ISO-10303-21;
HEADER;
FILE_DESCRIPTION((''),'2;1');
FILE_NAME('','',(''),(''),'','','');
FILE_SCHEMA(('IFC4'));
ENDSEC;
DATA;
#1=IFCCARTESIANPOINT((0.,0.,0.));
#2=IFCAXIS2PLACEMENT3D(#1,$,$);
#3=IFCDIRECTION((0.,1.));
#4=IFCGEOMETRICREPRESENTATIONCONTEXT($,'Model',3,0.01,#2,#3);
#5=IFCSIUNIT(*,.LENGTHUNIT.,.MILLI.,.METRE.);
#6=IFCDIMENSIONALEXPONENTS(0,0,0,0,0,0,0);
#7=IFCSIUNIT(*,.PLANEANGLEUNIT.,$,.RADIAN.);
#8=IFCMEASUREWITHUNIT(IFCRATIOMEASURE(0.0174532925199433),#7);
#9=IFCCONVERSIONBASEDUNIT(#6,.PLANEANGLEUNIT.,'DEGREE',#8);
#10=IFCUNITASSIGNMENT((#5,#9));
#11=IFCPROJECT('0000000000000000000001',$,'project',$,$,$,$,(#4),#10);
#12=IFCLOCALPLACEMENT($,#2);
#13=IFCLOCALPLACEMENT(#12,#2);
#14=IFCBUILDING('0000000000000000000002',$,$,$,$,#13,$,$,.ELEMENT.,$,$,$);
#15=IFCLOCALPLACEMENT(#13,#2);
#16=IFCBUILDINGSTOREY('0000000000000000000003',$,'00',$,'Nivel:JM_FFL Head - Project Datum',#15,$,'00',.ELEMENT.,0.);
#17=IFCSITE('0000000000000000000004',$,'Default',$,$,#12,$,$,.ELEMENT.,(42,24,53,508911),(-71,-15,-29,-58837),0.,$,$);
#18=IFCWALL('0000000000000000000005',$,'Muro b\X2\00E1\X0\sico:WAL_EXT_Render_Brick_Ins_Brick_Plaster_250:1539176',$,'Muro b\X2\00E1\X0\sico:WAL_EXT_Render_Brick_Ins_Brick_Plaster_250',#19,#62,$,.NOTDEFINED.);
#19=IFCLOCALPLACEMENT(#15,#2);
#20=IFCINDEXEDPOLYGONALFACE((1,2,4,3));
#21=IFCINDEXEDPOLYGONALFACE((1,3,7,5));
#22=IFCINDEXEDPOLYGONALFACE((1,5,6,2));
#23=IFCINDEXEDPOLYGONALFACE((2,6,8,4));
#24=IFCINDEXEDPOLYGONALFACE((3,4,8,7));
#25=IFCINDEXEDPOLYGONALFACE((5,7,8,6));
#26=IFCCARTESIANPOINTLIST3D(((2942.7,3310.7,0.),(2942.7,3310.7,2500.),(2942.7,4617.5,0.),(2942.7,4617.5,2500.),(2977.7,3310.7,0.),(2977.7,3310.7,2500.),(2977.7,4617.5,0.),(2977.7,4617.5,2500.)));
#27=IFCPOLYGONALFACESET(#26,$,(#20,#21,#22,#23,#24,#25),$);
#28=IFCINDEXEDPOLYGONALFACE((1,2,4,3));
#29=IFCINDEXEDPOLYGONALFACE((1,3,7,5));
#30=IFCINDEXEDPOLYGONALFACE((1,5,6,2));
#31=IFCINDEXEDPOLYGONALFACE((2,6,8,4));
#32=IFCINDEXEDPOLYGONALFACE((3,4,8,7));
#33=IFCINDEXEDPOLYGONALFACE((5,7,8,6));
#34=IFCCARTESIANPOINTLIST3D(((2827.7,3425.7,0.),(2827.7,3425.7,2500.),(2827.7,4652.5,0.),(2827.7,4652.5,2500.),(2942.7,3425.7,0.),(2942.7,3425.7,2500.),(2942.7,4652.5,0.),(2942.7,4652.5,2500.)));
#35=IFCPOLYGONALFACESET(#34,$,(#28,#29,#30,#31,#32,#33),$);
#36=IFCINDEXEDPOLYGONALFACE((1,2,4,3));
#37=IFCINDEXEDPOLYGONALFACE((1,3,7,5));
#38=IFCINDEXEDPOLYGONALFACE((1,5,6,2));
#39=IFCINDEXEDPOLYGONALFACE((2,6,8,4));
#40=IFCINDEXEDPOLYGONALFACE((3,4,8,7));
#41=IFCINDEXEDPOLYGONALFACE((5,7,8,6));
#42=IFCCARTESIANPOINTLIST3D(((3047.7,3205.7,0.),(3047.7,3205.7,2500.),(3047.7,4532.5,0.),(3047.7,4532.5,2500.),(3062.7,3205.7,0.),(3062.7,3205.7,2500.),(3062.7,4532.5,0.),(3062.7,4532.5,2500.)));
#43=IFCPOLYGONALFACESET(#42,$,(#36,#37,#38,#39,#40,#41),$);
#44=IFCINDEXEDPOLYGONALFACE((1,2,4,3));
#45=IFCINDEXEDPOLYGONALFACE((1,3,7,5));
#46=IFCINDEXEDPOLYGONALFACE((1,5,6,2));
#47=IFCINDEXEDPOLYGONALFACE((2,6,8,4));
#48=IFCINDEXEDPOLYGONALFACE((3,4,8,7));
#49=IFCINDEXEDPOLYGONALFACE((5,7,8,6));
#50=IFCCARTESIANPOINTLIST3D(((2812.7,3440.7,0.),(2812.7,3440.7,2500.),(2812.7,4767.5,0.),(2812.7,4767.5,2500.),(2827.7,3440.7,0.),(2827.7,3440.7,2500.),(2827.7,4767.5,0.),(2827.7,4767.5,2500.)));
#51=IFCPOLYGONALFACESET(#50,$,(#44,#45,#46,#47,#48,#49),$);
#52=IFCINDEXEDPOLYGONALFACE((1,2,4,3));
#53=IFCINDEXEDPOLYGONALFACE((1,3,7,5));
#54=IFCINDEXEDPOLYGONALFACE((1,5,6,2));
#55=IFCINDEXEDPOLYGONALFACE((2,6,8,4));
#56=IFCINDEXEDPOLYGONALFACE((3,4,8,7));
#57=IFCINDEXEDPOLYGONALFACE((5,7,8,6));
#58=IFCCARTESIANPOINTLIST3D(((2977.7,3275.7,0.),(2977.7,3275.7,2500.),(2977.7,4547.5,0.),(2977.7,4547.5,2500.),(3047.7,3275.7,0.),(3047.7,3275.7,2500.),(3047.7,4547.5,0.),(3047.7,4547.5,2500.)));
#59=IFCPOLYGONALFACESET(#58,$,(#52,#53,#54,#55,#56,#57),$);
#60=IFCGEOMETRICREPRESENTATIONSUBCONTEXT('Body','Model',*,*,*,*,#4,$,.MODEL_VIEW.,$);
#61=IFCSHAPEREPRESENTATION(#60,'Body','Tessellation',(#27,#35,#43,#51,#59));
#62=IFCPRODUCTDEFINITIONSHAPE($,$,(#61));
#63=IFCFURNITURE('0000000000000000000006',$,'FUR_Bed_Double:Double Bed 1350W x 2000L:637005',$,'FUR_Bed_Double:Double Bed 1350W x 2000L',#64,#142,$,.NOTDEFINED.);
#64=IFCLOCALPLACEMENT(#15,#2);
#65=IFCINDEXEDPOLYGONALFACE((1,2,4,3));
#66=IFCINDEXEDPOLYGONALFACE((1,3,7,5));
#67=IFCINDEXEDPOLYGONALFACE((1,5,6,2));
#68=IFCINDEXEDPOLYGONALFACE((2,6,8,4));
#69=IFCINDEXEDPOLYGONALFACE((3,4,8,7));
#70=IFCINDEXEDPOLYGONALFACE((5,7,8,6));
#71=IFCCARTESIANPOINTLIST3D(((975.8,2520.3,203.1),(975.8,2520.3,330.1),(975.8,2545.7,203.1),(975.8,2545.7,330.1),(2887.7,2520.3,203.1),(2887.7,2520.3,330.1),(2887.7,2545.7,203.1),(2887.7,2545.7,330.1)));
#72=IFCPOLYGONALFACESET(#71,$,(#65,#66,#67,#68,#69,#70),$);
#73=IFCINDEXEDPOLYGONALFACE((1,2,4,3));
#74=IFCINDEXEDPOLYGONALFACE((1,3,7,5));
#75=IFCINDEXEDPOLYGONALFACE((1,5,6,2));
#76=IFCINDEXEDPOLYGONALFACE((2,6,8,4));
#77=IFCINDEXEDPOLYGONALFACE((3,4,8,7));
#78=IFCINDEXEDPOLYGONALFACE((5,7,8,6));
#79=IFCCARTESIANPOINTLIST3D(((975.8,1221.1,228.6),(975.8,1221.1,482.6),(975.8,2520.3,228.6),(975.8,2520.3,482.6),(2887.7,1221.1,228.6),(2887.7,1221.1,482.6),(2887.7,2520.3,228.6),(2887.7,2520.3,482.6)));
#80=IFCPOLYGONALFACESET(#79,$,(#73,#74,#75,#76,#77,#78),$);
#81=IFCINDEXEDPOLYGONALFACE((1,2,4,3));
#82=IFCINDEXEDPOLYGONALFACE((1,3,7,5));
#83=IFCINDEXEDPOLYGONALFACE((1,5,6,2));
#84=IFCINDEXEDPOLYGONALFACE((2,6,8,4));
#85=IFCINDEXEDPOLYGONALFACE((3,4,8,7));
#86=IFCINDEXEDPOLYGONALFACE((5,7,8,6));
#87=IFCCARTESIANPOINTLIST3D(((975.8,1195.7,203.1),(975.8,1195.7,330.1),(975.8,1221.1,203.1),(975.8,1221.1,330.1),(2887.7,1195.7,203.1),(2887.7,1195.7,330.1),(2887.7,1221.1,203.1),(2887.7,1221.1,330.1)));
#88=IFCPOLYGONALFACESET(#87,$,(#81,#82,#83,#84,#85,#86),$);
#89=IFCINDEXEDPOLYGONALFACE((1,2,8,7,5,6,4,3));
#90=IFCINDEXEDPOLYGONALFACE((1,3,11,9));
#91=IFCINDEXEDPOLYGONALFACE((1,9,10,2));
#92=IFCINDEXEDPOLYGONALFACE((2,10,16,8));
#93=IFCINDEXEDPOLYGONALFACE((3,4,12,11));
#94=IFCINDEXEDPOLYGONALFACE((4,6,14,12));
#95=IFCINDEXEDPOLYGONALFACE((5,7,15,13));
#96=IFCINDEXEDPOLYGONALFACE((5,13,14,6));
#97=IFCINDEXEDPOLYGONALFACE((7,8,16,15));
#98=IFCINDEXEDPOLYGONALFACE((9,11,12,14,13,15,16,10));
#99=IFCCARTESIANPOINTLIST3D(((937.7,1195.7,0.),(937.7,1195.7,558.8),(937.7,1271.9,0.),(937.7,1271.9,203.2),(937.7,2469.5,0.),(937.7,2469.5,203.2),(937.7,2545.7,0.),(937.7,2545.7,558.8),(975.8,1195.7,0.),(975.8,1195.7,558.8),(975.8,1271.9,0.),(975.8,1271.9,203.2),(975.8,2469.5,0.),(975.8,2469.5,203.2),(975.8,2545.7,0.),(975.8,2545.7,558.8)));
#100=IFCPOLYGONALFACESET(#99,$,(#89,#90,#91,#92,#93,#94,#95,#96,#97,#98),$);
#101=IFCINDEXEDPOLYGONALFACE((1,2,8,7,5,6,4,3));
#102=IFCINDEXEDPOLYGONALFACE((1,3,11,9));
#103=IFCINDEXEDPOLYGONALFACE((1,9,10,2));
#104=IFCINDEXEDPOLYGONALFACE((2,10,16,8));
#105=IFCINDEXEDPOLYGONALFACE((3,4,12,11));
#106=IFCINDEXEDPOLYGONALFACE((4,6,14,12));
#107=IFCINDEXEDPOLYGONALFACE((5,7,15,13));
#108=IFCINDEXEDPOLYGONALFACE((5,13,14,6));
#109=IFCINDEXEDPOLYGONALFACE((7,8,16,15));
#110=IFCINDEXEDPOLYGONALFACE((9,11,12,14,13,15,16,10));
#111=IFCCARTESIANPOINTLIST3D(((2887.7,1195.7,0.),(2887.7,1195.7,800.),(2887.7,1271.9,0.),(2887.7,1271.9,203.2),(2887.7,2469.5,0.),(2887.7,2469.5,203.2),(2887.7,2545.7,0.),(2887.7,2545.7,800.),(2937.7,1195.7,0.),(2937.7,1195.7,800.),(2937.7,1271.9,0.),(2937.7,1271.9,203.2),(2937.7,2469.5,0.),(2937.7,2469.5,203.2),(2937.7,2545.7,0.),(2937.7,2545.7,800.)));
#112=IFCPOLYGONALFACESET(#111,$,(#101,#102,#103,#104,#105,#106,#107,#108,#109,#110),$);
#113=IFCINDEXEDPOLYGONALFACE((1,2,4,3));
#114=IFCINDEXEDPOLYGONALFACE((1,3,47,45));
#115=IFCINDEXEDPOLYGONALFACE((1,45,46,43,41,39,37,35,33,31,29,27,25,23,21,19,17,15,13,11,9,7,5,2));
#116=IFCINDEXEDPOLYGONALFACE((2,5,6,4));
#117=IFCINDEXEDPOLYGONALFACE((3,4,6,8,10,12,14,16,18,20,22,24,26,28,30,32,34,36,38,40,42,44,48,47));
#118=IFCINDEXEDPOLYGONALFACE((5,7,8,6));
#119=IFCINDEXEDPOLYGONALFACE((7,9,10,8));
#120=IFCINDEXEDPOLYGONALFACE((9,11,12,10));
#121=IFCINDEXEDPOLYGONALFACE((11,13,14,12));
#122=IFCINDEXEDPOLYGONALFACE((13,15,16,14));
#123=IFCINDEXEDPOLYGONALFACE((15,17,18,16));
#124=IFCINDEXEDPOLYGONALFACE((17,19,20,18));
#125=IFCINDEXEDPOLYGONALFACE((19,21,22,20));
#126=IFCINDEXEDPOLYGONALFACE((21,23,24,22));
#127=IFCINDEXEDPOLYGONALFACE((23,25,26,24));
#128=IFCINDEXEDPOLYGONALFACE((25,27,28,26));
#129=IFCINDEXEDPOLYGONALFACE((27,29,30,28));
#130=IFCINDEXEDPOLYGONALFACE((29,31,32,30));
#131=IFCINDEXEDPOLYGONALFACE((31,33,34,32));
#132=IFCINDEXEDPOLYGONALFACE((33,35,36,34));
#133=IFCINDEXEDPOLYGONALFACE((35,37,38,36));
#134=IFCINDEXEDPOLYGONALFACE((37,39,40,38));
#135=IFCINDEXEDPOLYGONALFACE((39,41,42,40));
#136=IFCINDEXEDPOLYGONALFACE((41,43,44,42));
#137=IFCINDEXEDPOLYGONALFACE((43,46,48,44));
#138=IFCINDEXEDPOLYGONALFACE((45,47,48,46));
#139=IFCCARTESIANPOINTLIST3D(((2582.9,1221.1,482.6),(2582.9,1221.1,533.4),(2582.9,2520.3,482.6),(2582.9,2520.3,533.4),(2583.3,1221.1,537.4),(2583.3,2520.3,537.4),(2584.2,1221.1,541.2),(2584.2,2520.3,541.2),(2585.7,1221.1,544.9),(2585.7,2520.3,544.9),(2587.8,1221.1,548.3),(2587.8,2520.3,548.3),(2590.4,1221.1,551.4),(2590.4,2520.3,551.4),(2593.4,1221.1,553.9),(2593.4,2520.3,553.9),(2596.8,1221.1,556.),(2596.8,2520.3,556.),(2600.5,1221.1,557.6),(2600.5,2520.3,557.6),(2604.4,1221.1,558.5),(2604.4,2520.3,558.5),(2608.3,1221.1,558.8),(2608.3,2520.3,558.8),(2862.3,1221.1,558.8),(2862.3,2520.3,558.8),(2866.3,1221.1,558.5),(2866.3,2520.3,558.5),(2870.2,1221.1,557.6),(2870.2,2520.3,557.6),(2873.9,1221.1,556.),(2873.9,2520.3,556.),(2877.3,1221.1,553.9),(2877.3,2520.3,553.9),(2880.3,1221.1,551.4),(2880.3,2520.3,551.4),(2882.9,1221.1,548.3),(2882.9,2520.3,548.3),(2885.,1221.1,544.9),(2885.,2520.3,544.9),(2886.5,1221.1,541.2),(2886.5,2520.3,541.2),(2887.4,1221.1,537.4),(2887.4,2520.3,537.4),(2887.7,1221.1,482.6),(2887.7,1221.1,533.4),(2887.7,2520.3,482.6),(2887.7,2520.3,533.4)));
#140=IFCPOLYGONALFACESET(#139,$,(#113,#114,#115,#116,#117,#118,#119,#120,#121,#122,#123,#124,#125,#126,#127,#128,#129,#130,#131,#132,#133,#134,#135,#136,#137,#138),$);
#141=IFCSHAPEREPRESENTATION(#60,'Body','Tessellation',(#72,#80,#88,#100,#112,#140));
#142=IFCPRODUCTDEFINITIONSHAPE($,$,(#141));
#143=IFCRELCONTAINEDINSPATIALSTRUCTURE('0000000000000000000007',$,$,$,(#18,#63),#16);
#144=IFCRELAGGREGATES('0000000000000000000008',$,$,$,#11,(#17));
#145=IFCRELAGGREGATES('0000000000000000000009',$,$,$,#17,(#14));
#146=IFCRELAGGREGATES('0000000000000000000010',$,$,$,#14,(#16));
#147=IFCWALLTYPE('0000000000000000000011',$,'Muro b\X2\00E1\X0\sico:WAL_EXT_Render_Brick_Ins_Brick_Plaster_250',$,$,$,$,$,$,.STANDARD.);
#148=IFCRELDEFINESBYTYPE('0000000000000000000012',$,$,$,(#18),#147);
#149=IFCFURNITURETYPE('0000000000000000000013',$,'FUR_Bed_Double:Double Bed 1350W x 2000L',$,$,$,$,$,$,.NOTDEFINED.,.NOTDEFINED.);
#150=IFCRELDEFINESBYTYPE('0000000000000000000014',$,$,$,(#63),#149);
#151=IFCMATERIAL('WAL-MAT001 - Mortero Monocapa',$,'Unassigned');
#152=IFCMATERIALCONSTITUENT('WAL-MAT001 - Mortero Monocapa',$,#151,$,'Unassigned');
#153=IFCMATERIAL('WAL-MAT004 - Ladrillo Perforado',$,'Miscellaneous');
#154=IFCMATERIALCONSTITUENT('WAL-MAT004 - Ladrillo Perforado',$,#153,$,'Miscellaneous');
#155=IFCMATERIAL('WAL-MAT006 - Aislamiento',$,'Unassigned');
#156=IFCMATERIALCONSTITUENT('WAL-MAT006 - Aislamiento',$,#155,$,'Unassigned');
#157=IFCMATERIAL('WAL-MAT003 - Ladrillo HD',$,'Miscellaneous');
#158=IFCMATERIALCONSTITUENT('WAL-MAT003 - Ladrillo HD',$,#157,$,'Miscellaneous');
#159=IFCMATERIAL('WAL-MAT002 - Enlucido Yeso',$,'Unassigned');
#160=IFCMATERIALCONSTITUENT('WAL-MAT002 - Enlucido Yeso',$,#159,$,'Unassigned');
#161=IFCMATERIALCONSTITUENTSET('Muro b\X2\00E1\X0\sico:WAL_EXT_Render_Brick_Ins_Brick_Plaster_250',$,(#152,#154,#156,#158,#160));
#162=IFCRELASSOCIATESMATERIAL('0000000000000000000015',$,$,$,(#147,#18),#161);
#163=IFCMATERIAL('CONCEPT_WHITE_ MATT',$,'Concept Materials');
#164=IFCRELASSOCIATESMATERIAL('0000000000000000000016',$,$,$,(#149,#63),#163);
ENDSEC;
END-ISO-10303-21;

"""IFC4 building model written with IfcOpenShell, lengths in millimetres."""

from ifc_helpers import new_model, entity, si_unit, converted_unit, direction, frame, origin, place, context, subcontext, project, spatial, indexed_curve, outline, extrude, source, transform, mapped, material, constituent, constituent_set, type_object, type_shapes, element, save


model = new_model("IFC4")

# Units and contexts
model_context = context("Model", 3, precision=0.01, world=origin(), true_north=direction((0.0, 1.0)))
body_context = subcontext(model_context, "Body", "Model", "MODEL_VIEW")
ifc_project = project(units=[si_unit("LENGTHUNIT", "METRE", prefix="MILLI"), converted_unit("PLANEANGLEUNIT", "DEGREE", entity("IfcRatioMeasure", 0.0174532925199433), si_unit("PLANEANGLEUNIT", "RADIAN"), dimensions=[0, 0, 0, 0, 0, 0, 0])], contexts=[model_context])

# Site, building, storey
site_placement = place(None, origin())
site = spatial("IfcSite", under=ifc_project, at=site_placement, Name="Default", CompositionType="ELEMENT", RefLatitude=(42, 24, 53, 508911), RefLongitude=(-71, -15, -29, -58837), RefElevation=0.0)
building_placement = place(site_placement, origin())
building = spatial("IfcBuilding", under=site, at=building_placement, CompositionType="ELEMENT")
storey_placement = place(building_placement, origin())
storey = spatial("IfcBuildingStorey", under=building, at=storey_placement, Name="00", ObjectType="Nivel:JM_FFL Head - Project Datum", LongName="00", CompositionType="ELEMENT", Elevation=0.0)

# Shared definitions
ifc_material_1 = material(Name="CONCEPT_WHITE_ MATT", Category="Concept Materials")

# Wall
ifc_material_2 = material(Name="WAL-MAT001 - Mortero Monocapa", Category="Unassigned")
ifc_material_3 = material(Name="WAL-MAT004 - Ladrillo Perforado", Category="Miscellaneous")
ifc_material_4 = material(Name="WAL-MAT006 - Aislamiento", Category="Unassigned")
ifc_material_5 = material(Name="WAL-MAT003 - Ladrillo HD", Category="Miscellaneous")
ifc_material_6 = material(Name="WAL-MAT002 - Enlucido Yeso", Category="Unassigned")
ifc_constituent_1 = constituent(ifc_material_2, Name="WAL-MAT001 - Mortero Monocapa", Category="Unassigned")
ifc_constituent_2 = constituent(ifc_material_3, Name="WAL-MAT004 - Ladrillo Perforado", Category="Miscellaneous")
ifc_constituent_3 = constituent(ifc_material_4, Name="WAL-MAT006 - Aislamiento", Category="Unassigned")
ifc_constituent_4 = constituent(ifc_material_5, Name="WAL-MAT003 - Ladrillo HD", Category="Miscellaneous")
ifc_constituent_5 = constituent(ifc_material_6, Name="WAL-MAT002 - Enlucido Yeso", Category="Unassigned")
ifc_constituent_set_1 = constituent_set(constituents=[ifc_constituent_1, ifc_constituent_2, ifc_constituent_3, ifc_constituent_4, ifc_constituent_5], Name="Muro básico:WAL_EXT_Render_Brick_Ins_Brick_Plaster_250")
wall_type_1 = type_object("IfcWallType", Name="Muro básico:WAL_EXT_Render_Brick_Ins_Brick_Plaster_250", PredefinedType="STANDARD", material=ifc_constituent_set_1)
wall_1_placement = place(storey_placement, frame((2937.7, 4532.5, 0.0), z_axis=(0.0, 0.0, 1.0), x_axis=(0.0, -1.0, 0.0)))
element("IfcWall", 1, at=wall_1_placement, inside=storey, type_object=wall_type_1, material=ifc_constituent_set_1, Name="Muro básico:WAL_EXT_Render_Brick_Ins_Brick_Plaster_250:1539176", ObjectType="Muro básico:WAL_EXT_Render_Brick_Ins_Brick_Plaster_250", PredefinedType="NOTDEFINED", context=body_context, shape_type="SweptSolid", body=[
    extrude(outline(indexed_curve([(-653.4, -17.5), (653.4, -17.5), (653.4, 17.5), (-653.4, 17.5), (-653.4, -17.5)], self_intersect=False)), frame((568.4, 22.5, 0.0)), (0.0, 0.0, 1.0), 2500.0),
    extrude(outline(indexed_curve([(-613.4, -57.5), (613.4, -57.5), (613.4, 57.5), (-613.4, 57.5), (-613.4, -57.5)], self_intersect=False)), frame((493.4, -52.5, 0.0)), (0.0, 0.0, 1.0), 2500.0),
    extrude(outline(indexed_curve([(-7.5, -663.4), (7.5, -663.4), (7.5, 663.4), (-7.5, 663.4), (-7.5, -663.4)], self_intersect=False)), frame((663.4, 117.5, 0.0), z_axis=(0.0, 0.0, 1.0), x_axis=(0.0, -1.0, 0.0)), (0.0, 0.0, 1.0), 2500.0),
    extrude(outline(indexed_curve([(-7.5, -663.4), (7.5, -663.4), (7.5, 663.4), (-7.5, 663.4), (-7.5, -663.4)], self_intersect=False)), frame((428.4, -117.5, 0.0), z_axis=(0.0, 0.0, 1.0), x_axis=(0.0, 1.0, 0.0)), (0.0, 0.0, 1.0), 2500.0),
    extrude(outline(indexed_curve([(-635.9, -35.0), (635.9, -35.0), (635.9, 35.0), (-635.9, 35.0), (-635.9, -35.0)], self_intersect=False)), frame((620.9, 75.0, 0.0)), (0.0, 0.0, 1.0), 2500.0),
])

# Furniture
furniture_type_1 = type_object("IfcFurnitureType", Name="FUR_Bed_Double:Double Bed 1350W x 2000L", AssemblyPlace="NOTDEFINED", PredefinedType="NOTDEFINED", material=ifc_material_1)
shared_shape_1 = source(origin(), body_context, "Body", "SweptSolid", [
    extrude(outline(indexed_curve([(-12.7, -956.0), (12.7, -956.0), (12.7, 956.0), (-12.7, 956.0), (-12.7, -956.0)], self_intersect=False)), frame((-681.4, -993.4, 203.1), z_axis=(0.0, 0.0, 1.0), x_axis=(-1.0, 0.0, 0.0)), (0.0, 0.0, 1.0), 127.0),
    extrude(outline(indexed_curve([(-649.6, -956.0), (649.6, -956.0), (649.6, 956.0), (-649.6, 956.0), (-649.6, -956.0)], self_intersect=False)), frame((-19.0, -993.5, 228.6), z_axis=(0.0, 0.0, 1.0), x_axis=(-1.0, 0.0, 0.0)), (0.0, 0.0, 1.0), 254.0),
    extrude(outline(indexed_curve([(-12.7, -956.0), (12.7, -956.0), (12.7, 956.0), (-12.7, 956.0), (-12.7, -956.0)], self_intersect=False)), frame((643.2, -993.4, 203.1)), (0.0, 0.0, 1.0), 127.0),
    extrude(outline(indexed_curve([(598.8, -190.5), (675.0, -190.5), (675.0, 368.3), (-675.0, 368.3), (-675.0, -190.5), (-598.8, -190.5), (-598.8, 12.7), (598.8, 12.7), (598.8, -190.5)], self_intersect=False)), frame((-19.1, -1987.5, 190.5), z_axis=(0.0, 1.0, 0.0), x_axis=(-1.0, 0.0, 0.0)), (0.0, 0.0, 1.0), 38.1),
    extrude(outline(indexed_curve([(-549.2, -675.0), (250.8, -675.0), (250.8, -598.8), (47.6, -598.8), (47.6, 598.8), (250.8, 598.8), (250.8, 675.0), (-549.2, 675.0), (-549.2, -675.0)], self_intersect=False)), frame((-19.1, -37.5, 250.8), z_axis=(0.0, 1.0, 0.0), x_axis=(0.0, 0.0, -1.0)), (0.0, 0.0, 1.0), 50.0),
    extrude(outline(indexed_curve([(152.4, 8.5), (152.1, 12.4), (151.2, 16.3), (149.6, 20.0), (147.5, 23.4), (145.0, 26.4), (141.9, 29.0), (138.5, 31.1), (134.8, 32.6), (131.0, 33.6), (127.0, 33.9), (-127.0, 33.9), (-131.0, 33.6), (-134.8, 32.6), (-138.5, 31.1), (-141.9, 29.0), (-145.0, 26.4), (-147.5, 23.4), (-149.6, 20.0), (-151.2, 16.3), (-152.1, 12.4), (-152.4, 8.5), (-152.4, -42.3), (152.4, -42.3), (152.4, 8.5)], self_intersect=False)), frame((-668.6, -189.9, 524.9), z_axis=(1.0, 0.0, 0.0), x_axis=(0.0, 1.0, 0.0)), (0.0, 0.0, 1.0), 1299.2),
])
type_shapes(furniture_type_1, [shared_shape_1])
for number, where, z_axis, x_axis, name in (
    (2, (2925.2, 1851.7, 0.0), (0.0, 0.0, 1.0), (0.0, -1.0, 0.0), "FUR_Bed_Double:Double Bed 1350W x 2000L:637005"),
):
    element("IfcFurniture", number, at=place(storey_placement, frame(where, z_axis=z_axis, x_axis=x_axis)), inside=storey, type_object=furniture_type_1, material=ifc_material_1, Name=name, ObjectType="FUR_Bed_Double:Double Bed 1350W x 2000L", PredefinedType="NOTDEFINED", context=body_context, shape_type="MappedRepresentation", body=[
        mapped(shared_shape_1, transform((0.0, 0.0, 0.0), scale=1.0)),
    ])

save(model, "model.ifc")
